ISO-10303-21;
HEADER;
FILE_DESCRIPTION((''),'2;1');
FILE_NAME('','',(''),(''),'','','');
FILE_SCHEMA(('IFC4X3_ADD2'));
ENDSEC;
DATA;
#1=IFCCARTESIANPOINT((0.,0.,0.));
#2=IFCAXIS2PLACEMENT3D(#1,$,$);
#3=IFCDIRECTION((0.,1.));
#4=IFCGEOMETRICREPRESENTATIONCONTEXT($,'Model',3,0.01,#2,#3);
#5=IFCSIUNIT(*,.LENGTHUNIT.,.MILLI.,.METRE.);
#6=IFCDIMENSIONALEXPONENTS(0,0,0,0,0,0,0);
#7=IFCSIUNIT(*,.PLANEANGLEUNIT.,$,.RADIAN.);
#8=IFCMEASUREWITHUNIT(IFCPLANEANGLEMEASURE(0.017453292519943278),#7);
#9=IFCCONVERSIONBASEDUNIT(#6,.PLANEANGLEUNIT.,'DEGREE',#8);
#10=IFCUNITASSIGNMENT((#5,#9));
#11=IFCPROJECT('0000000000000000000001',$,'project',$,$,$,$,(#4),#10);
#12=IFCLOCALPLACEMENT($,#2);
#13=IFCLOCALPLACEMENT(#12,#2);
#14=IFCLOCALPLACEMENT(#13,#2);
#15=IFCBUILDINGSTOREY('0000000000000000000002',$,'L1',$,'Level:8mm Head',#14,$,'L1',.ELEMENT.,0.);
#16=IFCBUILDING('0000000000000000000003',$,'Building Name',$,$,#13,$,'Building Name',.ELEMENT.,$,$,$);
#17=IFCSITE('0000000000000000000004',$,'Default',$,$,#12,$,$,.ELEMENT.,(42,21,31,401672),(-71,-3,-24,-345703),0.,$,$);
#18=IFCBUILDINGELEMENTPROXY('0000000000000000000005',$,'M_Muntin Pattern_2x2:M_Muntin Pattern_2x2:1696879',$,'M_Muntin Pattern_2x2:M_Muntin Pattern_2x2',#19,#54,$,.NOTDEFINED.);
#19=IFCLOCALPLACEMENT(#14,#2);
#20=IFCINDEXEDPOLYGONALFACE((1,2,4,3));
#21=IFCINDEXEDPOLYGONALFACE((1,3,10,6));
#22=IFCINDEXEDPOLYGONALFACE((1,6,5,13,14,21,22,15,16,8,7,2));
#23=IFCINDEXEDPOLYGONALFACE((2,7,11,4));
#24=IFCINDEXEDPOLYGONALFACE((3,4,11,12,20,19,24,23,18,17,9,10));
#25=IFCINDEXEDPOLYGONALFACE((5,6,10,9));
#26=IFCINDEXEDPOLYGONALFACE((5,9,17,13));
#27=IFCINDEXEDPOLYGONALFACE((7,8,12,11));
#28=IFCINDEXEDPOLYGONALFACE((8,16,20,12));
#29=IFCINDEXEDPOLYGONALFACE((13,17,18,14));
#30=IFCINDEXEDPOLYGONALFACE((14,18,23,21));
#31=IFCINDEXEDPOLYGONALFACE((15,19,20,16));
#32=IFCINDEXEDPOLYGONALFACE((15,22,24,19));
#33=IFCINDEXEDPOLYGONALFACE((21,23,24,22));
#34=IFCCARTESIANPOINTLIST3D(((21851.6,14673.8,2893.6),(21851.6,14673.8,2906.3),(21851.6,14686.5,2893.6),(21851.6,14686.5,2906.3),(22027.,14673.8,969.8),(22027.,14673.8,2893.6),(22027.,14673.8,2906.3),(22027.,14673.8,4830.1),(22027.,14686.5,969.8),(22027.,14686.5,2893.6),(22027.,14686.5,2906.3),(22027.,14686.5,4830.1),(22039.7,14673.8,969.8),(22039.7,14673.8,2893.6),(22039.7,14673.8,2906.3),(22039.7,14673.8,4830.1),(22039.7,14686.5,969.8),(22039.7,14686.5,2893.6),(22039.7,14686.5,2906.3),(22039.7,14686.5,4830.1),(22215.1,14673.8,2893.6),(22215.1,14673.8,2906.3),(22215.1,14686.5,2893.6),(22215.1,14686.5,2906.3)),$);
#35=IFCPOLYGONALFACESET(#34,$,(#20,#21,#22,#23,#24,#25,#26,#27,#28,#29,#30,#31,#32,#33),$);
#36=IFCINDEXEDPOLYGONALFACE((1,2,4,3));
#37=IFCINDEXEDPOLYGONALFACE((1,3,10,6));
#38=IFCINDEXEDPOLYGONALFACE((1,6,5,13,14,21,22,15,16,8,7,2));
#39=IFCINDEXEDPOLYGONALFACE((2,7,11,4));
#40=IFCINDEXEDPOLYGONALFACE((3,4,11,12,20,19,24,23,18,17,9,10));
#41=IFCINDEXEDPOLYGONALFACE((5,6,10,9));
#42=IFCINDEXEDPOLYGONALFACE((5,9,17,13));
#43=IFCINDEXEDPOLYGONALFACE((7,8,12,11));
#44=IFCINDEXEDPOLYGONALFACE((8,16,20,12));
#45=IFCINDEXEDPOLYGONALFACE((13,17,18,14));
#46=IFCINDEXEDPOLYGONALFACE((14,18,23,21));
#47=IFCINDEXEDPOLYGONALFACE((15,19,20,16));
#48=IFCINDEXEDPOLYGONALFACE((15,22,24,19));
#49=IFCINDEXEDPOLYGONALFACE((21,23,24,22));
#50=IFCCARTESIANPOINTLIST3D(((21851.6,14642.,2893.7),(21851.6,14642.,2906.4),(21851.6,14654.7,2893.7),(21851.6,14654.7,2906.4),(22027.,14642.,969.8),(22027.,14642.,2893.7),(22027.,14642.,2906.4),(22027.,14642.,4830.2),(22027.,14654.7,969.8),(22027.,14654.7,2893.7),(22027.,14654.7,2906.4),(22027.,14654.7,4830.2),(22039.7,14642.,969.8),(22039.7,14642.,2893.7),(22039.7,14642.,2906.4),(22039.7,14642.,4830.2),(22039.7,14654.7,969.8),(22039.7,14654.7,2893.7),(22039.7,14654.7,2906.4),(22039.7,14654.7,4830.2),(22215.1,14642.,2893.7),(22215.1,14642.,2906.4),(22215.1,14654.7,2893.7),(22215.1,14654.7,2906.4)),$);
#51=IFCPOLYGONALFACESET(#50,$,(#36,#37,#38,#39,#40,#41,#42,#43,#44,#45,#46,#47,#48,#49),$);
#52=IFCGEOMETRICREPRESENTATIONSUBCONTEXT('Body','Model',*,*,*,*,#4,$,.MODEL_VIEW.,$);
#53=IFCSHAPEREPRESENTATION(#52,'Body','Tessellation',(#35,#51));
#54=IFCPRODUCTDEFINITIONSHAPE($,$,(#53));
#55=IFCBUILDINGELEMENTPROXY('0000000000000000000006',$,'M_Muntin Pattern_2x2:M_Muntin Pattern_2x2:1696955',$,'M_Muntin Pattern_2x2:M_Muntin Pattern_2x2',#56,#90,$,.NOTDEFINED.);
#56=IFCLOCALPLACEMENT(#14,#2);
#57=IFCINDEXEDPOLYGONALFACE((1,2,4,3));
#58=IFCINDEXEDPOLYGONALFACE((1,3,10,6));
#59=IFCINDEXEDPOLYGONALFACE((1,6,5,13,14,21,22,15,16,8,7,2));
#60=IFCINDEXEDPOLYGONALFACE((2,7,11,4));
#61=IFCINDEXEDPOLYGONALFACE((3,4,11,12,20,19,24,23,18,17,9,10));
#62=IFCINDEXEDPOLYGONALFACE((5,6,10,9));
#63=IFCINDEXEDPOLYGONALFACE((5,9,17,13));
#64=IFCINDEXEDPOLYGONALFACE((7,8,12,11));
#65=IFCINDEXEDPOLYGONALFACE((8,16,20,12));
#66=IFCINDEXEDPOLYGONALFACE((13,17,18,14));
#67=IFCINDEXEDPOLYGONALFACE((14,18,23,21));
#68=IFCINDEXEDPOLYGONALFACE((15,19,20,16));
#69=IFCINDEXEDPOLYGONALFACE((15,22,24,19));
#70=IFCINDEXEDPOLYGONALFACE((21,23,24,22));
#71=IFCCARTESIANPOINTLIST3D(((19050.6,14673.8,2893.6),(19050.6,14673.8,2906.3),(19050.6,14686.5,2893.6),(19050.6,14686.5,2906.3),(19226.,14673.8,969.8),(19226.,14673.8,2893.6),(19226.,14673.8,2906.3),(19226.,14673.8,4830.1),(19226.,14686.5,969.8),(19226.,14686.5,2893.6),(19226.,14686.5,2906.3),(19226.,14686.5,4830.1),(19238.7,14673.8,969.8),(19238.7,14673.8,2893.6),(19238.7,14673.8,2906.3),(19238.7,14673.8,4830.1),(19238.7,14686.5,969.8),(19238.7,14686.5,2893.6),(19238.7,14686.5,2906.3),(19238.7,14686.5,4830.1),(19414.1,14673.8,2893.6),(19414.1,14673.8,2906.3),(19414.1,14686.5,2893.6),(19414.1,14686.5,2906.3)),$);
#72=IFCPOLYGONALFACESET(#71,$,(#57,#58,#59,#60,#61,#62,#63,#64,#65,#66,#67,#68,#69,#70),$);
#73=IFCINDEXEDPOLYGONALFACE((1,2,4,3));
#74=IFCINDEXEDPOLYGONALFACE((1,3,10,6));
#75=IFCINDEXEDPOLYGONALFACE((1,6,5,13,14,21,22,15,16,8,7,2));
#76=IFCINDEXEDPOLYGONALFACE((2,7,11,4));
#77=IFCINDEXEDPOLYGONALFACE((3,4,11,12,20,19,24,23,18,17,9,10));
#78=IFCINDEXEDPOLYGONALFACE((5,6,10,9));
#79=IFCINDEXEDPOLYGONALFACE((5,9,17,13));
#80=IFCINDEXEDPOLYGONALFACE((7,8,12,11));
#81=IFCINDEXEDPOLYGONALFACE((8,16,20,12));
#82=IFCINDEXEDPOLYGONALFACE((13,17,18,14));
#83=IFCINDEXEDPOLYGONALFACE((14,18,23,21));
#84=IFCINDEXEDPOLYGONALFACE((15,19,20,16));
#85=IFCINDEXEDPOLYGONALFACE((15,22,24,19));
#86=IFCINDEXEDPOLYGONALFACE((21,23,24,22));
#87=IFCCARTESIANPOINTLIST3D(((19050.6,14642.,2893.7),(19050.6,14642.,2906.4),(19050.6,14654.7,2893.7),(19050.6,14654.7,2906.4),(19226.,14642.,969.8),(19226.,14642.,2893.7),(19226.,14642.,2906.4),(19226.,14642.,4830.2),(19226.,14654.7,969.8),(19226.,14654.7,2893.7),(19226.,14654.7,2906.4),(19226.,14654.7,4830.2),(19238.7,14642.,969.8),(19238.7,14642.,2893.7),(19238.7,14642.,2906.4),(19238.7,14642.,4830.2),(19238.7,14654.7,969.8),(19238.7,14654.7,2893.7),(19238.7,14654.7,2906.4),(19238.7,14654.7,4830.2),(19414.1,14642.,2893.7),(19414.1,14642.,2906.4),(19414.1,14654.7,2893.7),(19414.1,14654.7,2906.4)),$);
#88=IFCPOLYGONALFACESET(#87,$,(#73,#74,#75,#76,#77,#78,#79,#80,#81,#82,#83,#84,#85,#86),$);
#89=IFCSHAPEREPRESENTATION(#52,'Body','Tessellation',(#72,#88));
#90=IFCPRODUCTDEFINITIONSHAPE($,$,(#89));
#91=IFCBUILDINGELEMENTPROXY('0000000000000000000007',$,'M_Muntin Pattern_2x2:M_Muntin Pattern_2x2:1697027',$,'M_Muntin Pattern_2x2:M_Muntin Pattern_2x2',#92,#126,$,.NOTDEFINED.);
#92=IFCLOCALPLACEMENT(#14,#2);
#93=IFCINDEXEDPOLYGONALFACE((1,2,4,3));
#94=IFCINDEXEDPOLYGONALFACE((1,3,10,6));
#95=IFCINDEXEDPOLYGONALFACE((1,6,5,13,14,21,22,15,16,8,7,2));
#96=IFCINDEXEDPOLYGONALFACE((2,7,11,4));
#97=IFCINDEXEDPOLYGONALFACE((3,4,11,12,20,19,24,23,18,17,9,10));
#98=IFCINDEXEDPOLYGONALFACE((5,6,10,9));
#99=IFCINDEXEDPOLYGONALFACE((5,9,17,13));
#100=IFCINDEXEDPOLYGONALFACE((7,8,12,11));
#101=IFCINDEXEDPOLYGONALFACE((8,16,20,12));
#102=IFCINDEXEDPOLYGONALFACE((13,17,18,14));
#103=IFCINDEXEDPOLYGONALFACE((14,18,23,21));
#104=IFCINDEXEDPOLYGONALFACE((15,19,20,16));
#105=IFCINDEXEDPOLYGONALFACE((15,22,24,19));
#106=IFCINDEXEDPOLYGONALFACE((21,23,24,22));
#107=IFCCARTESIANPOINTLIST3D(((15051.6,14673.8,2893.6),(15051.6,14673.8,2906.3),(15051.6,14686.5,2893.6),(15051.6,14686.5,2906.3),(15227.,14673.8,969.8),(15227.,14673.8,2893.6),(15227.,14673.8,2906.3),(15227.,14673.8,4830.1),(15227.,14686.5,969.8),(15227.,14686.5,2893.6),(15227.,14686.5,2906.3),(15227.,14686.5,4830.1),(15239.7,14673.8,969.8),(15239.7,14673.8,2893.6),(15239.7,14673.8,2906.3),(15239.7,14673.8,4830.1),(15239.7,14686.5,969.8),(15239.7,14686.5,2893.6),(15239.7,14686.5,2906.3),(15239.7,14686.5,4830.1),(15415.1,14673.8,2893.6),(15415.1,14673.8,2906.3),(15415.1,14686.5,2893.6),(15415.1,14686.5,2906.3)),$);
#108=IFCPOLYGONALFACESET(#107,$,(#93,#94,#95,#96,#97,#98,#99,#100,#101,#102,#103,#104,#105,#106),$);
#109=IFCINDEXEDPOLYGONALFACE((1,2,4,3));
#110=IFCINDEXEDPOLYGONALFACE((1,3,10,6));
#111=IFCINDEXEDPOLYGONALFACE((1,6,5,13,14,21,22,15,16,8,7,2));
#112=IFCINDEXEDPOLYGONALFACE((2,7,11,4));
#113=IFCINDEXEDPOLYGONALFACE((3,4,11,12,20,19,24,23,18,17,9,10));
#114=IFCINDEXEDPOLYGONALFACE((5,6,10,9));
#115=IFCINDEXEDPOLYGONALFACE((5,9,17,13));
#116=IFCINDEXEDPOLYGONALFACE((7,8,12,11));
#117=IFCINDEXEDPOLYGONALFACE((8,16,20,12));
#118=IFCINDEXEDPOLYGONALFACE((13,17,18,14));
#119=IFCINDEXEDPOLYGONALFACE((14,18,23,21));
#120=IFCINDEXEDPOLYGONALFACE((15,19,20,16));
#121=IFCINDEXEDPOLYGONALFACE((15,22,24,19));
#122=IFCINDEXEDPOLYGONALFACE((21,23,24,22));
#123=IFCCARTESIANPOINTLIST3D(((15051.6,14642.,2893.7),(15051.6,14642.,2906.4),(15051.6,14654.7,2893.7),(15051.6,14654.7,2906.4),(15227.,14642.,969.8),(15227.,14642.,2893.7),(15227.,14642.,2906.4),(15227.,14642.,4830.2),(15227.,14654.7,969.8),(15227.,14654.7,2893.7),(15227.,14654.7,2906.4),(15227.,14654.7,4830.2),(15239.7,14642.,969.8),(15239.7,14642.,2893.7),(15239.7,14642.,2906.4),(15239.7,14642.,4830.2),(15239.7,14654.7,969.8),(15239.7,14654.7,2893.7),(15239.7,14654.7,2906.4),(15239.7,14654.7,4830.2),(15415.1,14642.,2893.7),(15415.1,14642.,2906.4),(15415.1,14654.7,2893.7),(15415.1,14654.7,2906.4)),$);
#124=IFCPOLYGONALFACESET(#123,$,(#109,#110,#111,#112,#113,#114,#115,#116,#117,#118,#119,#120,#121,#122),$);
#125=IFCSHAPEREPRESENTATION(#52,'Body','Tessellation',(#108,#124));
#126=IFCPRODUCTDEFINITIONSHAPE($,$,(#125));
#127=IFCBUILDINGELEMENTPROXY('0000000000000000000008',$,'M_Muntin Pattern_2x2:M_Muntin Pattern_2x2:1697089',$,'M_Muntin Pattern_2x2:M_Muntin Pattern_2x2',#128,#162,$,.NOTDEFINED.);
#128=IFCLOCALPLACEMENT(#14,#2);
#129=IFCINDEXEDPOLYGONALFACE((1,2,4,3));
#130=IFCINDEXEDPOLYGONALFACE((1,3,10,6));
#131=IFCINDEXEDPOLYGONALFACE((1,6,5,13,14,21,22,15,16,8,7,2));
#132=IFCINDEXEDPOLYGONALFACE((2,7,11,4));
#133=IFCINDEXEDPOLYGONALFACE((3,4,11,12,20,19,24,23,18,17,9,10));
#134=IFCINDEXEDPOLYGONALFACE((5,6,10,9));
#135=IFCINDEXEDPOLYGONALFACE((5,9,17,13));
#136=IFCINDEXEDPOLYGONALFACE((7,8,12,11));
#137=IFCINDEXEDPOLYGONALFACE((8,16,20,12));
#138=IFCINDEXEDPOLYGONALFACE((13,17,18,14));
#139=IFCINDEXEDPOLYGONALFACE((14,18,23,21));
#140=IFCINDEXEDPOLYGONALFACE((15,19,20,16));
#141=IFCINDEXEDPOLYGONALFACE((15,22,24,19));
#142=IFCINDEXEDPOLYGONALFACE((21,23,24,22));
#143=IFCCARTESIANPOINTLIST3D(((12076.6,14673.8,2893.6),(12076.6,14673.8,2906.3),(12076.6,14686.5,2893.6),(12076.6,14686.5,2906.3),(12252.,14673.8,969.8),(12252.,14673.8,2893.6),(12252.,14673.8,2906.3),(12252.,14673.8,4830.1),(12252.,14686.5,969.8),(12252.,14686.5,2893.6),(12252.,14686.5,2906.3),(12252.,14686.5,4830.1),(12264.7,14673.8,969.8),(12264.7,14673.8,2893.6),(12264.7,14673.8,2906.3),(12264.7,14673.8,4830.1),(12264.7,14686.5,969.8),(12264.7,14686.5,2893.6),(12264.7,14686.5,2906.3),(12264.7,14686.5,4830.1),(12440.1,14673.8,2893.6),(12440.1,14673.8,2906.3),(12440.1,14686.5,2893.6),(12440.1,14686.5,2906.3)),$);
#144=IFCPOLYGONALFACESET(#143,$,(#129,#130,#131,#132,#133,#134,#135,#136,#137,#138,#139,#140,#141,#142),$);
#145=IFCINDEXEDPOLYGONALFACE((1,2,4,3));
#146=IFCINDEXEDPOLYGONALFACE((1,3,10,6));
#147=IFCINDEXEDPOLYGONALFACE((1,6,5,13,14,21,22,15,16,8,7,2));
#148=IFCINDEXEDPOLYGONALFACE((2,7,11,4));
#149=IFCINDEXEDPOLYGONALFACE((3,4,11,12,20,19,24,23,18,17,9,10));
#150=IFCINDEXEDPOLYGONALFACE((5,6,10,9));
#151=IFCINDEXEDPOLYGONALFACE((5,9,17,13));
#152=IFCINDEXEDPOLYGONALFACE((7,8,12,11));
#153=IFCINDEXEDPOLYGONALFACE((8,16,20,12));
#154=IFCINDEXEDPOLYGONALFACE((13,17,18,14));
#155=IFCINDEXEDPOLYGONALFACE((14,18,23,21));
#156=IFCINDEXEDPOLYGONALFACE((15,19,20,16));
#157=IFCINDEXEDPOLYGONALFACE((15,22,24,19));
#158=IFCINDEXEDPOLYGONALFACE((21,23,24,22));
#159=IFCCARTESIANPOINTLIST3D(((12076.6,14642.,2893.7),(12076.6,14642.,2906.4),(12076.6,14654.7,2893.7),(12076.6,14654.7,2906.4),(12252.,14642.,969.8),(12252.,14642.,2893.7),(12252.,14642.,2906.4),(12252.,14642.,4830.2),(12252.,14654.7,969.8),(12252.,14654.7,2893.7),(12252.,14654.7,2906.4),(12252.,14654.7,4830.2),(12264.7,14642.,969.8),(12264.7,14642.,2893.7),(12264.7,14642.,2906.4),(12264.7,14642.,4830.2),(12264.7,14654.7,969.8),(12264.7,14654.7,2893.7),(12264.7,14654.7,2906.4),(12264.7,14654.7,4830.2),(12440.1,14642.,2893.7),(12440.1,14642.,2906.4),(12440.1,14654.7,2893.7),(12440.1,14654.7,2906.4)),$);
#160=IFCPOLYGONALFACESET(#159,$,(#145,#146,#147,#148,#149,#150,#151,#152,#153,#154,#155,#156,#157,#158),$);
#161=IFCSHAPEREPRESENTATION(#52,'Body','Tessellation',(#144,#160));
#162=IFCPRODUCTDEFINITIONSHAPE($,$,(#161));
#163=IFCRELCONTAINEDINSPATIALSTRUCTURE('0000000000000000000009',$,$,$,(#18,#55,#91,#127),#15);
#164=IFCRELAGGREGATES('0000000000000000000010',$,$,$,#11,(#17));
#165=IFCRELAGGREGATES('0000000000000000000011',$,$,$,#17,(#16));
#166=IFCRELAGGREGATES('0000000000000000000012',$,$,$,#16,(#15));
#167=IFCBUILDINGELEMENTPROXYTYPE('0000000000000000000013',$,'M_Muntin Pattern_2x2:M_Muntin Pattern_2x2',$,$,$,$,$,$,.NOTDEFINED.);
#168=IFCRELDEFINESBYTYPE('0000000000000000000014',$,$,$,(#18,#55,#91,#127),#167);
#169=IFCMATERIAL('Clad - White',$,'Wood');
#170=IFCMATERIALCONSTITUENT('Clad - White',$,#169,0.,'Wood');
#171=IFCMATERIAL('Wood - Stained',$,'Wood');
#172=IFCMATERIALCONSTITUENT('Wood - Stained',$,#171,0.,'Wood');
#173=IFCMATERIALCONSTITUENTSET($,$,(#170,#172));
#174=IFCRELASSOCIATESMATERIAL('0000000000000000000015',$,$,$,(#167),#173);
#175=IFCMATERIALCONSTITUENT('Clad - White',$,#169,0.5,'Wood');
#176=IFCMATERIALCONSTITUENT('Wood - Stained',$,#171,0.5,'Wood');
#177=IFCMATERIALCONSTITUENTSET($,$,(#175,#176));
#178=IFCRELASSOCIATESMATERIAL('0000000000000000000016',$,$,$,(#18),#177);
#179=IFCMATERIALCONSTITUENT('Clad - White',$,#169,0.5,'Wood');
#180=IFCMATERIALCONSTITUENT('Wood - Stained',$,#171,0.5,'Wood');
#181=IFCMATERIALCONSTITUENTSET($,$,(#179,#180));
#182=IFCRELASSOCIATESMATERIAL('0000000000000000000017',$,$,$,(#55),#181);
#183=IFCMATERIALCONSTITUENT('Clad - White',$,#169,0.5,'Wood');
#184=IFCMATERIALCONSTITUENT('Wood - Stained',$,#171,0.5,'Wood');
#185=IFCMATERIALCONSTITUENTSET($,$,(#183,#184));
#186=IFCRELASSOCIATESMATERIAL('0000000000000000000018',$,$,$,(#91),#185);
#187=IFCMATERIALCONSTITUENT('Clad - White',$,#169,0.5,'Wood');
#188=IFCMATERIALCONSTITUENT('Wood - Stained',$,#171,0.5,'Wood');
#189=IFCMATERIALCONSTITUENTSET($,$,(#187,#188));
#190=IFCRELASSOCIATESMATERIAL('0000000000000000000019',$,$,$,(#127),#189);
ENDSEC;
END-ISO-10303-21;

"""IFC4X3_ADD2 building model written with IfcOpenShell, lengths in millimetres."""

from ifc_helpers import new_model, entity, si_unit, converted_unit, direction, frame, origin, place, context, subcontext, project, spatial, polyline, outline, extrude, source, transform, mapped, material, constituent, constituent_set, type_object, type_shapes, element, save


model = new_model("IFC4X3_ADD2")

# Units and contexts
model_context = context("Model", 3, precision=0.01, world=origin(), true_north=direction((0.0, 1.0)))
body_context = subcontext(model_context, "Body", "Model", "MODEL_VIEW")
ifc_project = project(units=[si_unit("LENGTHUNIT", "METRE", prefix="MILLI"), converted_unit("PLANEANGLEUNIT", "DEGREE", entity("IfcPlaneAngleMeasure", 0.017453292519943278), si_unit("PLANEANGLEUNIT", "RADIAN"), dimensions=[0, 0, 0, 0, 0, 0, 0])], contexts=[model_context])

# Site, building, storey
site_placement = place(None, origin())
site = spatial("IfcSite", under=ifc_project, at=site_placement, Name="Default", CompositionType="ELEMENT", RefLatitude=(42, 21, 31, 401672), RefLongitude=(-71, -3, -24, -345703), RefElevation=0.0)
building_placement = place(site_placement, origin())
building = spatial("IfcBuilding", under=site, at=building_placement, Name="Building Name", LongName="Building Name", CompositionType="ELEMENT")
storey_placement = place(building_placement, origin())
storey = spatial("IfcBuildingStorey", under=building, at=storey_placement, Name="L1", ObjectType="Level:8mm Head", LongName="L1", CompositionType="ELEMENT", Elevation=0.0)

# Building element proxies
ifc_material_1 = material(Name="Clad - White", Category="Wood")
ifc_constituent_1 = constituent(ifc_material_1, Name="Clad - White", Category="Wood", fraction=0.5)
ifc_material_2 = material(Name="Wood - Stained", Category="Wood")
ifc_constituent_2 = constituent(ifc_material_2, Name="Wood - Stained", Category="Wood", fraction=0.5)
ifc_constituent_set_1 = constituent_set(constituents=[ifc_constituent_1, ifc_constituent_2])
ifc_constituent_3 = constituent(ifc_material_1, Name="Clad - White", Category="Wood", fraction=0.0)
ifc_constituent_4 = constituent(ifc_material_2, Name="Wood - Stained", Category="Wood", fraction=0.0)
ifc_constituent_set_2 = constituent_set(constituents=[ifc_constituent_3, ifc_constituent_4])
building_element_proxy_type_1 = type_object("IfcBuildingElementProxyType", Name="M_Muntin Pattern_2x2:M_Muntin Pattern_2x2", PredefinedType="NOTDEFINED", material=ifc_constituent_set_2)
shared_shape_1 = source(origin(), body_context, "Body", "SweptSolid", [
    extrude(outline(polyline([(6.4, -6.4), (1930.1, -6.4), (1930.1, 6.3), (6.4, 6.3), (6.4, 181.7), (-6.3, 181.7), (-6.3, 6.3), (-1930.2, 6.3), (-1930.2, -6.4), (-6.3, -6.4), (-6.3, -181.7), (6.4, -181.7), (6.4, -6.4)])), frame((0.0, 9.5, 1930.1), z_axis=(0.0, 1.0, 0.0), x_axis=(0.0, 0.0, 1.0)), (0.0, 0.0, 1.0), 12.7),
    extrude(outline(polyline([(6.4, -6.4), (1930.2, -6.4), (1930.2, 6.3), (6.4, 6.3), (6.4, 181.7), (-6.3, 181.7), (-6.3, 6.3), (-1930.2, 6.3), (-1930.2, -6.4), (-6.3, -6.4), (-6.3, -181.7), (6.4, -181.7), (6.4, -6.4)])), frame((0.0, -22.2, 1930.2), z_axis=(0.0, 1.0, 0.0), x_axis=(0.0, 0.0, 1.0)), (0.0, 0.0, 1.0), 12.7),
])
type_shapes(building_element_proxy_type_1, [shared_shape_1])
proxy_1_placement = place(storey_placement, frame((22033.4, 14664.3, 969.8)))
element("IfcBuildingElementProxy", 1, at=proxy_1_placement, inside=storey, type_object=building_element_proxy_type_1, material=ifc_constituent_set_1, Name="M_Muntin Pattern_2x2:M_Muntin Pattern_2x2:1696879", ObjectType="M_Muntin Pattern_2x2:M_Muntin Pattern_2x2", PredefinedType="NOTDEFINED", context=body_context, shape_type="MappedRepresentation", body=[
    mapped(shared_shape_1, transform((0.0, 0.0, 0.0), scale=1.0)),
])
ifc_constituent_5 = constituent(ifc_material_1, Name="Clad - White", Category="Wood", fraction=0.5)
ifc_constituent_6 = constituent(ifc_material_2, Name="Wood - Stained", Category="Wood", fraction=0.5)
ifc_constituent_set_3 = constituent_set(constituents=[ifc_constituent_5, ifc_constituent_6])
proxy_2_placement = place(storey_placement, frame((19232.4, 14664.3, 969.8)))
element("IfcBuildingElementProxy", 2, at=proxy_2_placement, inside=storey, type_object=building_element_proxy_type_1, material=ifc_constituent_set_3, Name="M_Muntin Pattern_2x2:M_Muntin Pattern_2x2:1696955", ObjectType="M_Muntin Pattern_2x2:M_Muntin Pattern_2x2", PredefinedType="NOTDEFINED", context=body_context, shape_type="MappedRepresentation", body=[
    mapped(shared_shape_1, transform((0.0, 0.0, 0.0), scale=1.0)),
])
ifc_constituent_7 = constituent(ifc_material_1, Name="Clad - White", Category="Wood", fraction=0.5)
ifc_constituent_8 = constituent(ifc_material_2, Name="Wood - Stained", Category="Wood", fraction=0.5)
ifc_constituent_set_4 = constituent_set(constituents=[ifc_constituent_7, ifc_constituent_8])
proxy_3_placement = place(storey_placement, frame((15233.4, 14664.3, 969.8)))
element("IfcBuildingElementProxy", 3, at=proxy_3_placement, inside=storey, type_object=building_element_proxy_type_1, material=ifc_constituent_set_4, Name="M_Muntin Pattern_2x2:M_Muntin Pattern_2x2:1697027", ObjectType="M_Muntin Pattern_2x2:M_Muntin Pattern_2x2", PredefinedType="NOTDEFINED", context=body_context, shape_type="MappedRepresentation", body=[
    mapped(shared_shape_1, transform((0.0, 0.0, 0.0), scale=1.0)),
])
ifc_constituent_9 = constituent(ifc_material_1, Name="Clad - White", Category="Wood", fraction=0.5)
ifc_constituent_10 = constituent(ifc_material_2, Name="Wood - Stained", Category="Wood", fraction=0.5)
ifc_constituent_set_5 = constituent_set(constituents=[ifc_constituent_9, ifc_constituent_10])
proxy_4_placement = place(storey_placement, frame((12258.4, 14664.3, 969.8)))
element("IfcBuildingElementProxy", 4, at=proxy_4_placement, inside=storey, type_object=building_element_proxy_type_1, material=ifc_constituent_set_5, Name="M_Muntin Pattern_2x2:M_Muntin Pattern_2x2:1697089", ObjectType="M_Muntin Pattern_2x2:M_Muntin Pattern_2x2", PredefinedType="NOTDEFINED", context=body_context, shape_type="MappedRepresentation", body=[
    mapped(shared_shape_1, transform((0.0, 0.0, 0.0), scale=1.0)),
])

save(model, "model.ifc")
